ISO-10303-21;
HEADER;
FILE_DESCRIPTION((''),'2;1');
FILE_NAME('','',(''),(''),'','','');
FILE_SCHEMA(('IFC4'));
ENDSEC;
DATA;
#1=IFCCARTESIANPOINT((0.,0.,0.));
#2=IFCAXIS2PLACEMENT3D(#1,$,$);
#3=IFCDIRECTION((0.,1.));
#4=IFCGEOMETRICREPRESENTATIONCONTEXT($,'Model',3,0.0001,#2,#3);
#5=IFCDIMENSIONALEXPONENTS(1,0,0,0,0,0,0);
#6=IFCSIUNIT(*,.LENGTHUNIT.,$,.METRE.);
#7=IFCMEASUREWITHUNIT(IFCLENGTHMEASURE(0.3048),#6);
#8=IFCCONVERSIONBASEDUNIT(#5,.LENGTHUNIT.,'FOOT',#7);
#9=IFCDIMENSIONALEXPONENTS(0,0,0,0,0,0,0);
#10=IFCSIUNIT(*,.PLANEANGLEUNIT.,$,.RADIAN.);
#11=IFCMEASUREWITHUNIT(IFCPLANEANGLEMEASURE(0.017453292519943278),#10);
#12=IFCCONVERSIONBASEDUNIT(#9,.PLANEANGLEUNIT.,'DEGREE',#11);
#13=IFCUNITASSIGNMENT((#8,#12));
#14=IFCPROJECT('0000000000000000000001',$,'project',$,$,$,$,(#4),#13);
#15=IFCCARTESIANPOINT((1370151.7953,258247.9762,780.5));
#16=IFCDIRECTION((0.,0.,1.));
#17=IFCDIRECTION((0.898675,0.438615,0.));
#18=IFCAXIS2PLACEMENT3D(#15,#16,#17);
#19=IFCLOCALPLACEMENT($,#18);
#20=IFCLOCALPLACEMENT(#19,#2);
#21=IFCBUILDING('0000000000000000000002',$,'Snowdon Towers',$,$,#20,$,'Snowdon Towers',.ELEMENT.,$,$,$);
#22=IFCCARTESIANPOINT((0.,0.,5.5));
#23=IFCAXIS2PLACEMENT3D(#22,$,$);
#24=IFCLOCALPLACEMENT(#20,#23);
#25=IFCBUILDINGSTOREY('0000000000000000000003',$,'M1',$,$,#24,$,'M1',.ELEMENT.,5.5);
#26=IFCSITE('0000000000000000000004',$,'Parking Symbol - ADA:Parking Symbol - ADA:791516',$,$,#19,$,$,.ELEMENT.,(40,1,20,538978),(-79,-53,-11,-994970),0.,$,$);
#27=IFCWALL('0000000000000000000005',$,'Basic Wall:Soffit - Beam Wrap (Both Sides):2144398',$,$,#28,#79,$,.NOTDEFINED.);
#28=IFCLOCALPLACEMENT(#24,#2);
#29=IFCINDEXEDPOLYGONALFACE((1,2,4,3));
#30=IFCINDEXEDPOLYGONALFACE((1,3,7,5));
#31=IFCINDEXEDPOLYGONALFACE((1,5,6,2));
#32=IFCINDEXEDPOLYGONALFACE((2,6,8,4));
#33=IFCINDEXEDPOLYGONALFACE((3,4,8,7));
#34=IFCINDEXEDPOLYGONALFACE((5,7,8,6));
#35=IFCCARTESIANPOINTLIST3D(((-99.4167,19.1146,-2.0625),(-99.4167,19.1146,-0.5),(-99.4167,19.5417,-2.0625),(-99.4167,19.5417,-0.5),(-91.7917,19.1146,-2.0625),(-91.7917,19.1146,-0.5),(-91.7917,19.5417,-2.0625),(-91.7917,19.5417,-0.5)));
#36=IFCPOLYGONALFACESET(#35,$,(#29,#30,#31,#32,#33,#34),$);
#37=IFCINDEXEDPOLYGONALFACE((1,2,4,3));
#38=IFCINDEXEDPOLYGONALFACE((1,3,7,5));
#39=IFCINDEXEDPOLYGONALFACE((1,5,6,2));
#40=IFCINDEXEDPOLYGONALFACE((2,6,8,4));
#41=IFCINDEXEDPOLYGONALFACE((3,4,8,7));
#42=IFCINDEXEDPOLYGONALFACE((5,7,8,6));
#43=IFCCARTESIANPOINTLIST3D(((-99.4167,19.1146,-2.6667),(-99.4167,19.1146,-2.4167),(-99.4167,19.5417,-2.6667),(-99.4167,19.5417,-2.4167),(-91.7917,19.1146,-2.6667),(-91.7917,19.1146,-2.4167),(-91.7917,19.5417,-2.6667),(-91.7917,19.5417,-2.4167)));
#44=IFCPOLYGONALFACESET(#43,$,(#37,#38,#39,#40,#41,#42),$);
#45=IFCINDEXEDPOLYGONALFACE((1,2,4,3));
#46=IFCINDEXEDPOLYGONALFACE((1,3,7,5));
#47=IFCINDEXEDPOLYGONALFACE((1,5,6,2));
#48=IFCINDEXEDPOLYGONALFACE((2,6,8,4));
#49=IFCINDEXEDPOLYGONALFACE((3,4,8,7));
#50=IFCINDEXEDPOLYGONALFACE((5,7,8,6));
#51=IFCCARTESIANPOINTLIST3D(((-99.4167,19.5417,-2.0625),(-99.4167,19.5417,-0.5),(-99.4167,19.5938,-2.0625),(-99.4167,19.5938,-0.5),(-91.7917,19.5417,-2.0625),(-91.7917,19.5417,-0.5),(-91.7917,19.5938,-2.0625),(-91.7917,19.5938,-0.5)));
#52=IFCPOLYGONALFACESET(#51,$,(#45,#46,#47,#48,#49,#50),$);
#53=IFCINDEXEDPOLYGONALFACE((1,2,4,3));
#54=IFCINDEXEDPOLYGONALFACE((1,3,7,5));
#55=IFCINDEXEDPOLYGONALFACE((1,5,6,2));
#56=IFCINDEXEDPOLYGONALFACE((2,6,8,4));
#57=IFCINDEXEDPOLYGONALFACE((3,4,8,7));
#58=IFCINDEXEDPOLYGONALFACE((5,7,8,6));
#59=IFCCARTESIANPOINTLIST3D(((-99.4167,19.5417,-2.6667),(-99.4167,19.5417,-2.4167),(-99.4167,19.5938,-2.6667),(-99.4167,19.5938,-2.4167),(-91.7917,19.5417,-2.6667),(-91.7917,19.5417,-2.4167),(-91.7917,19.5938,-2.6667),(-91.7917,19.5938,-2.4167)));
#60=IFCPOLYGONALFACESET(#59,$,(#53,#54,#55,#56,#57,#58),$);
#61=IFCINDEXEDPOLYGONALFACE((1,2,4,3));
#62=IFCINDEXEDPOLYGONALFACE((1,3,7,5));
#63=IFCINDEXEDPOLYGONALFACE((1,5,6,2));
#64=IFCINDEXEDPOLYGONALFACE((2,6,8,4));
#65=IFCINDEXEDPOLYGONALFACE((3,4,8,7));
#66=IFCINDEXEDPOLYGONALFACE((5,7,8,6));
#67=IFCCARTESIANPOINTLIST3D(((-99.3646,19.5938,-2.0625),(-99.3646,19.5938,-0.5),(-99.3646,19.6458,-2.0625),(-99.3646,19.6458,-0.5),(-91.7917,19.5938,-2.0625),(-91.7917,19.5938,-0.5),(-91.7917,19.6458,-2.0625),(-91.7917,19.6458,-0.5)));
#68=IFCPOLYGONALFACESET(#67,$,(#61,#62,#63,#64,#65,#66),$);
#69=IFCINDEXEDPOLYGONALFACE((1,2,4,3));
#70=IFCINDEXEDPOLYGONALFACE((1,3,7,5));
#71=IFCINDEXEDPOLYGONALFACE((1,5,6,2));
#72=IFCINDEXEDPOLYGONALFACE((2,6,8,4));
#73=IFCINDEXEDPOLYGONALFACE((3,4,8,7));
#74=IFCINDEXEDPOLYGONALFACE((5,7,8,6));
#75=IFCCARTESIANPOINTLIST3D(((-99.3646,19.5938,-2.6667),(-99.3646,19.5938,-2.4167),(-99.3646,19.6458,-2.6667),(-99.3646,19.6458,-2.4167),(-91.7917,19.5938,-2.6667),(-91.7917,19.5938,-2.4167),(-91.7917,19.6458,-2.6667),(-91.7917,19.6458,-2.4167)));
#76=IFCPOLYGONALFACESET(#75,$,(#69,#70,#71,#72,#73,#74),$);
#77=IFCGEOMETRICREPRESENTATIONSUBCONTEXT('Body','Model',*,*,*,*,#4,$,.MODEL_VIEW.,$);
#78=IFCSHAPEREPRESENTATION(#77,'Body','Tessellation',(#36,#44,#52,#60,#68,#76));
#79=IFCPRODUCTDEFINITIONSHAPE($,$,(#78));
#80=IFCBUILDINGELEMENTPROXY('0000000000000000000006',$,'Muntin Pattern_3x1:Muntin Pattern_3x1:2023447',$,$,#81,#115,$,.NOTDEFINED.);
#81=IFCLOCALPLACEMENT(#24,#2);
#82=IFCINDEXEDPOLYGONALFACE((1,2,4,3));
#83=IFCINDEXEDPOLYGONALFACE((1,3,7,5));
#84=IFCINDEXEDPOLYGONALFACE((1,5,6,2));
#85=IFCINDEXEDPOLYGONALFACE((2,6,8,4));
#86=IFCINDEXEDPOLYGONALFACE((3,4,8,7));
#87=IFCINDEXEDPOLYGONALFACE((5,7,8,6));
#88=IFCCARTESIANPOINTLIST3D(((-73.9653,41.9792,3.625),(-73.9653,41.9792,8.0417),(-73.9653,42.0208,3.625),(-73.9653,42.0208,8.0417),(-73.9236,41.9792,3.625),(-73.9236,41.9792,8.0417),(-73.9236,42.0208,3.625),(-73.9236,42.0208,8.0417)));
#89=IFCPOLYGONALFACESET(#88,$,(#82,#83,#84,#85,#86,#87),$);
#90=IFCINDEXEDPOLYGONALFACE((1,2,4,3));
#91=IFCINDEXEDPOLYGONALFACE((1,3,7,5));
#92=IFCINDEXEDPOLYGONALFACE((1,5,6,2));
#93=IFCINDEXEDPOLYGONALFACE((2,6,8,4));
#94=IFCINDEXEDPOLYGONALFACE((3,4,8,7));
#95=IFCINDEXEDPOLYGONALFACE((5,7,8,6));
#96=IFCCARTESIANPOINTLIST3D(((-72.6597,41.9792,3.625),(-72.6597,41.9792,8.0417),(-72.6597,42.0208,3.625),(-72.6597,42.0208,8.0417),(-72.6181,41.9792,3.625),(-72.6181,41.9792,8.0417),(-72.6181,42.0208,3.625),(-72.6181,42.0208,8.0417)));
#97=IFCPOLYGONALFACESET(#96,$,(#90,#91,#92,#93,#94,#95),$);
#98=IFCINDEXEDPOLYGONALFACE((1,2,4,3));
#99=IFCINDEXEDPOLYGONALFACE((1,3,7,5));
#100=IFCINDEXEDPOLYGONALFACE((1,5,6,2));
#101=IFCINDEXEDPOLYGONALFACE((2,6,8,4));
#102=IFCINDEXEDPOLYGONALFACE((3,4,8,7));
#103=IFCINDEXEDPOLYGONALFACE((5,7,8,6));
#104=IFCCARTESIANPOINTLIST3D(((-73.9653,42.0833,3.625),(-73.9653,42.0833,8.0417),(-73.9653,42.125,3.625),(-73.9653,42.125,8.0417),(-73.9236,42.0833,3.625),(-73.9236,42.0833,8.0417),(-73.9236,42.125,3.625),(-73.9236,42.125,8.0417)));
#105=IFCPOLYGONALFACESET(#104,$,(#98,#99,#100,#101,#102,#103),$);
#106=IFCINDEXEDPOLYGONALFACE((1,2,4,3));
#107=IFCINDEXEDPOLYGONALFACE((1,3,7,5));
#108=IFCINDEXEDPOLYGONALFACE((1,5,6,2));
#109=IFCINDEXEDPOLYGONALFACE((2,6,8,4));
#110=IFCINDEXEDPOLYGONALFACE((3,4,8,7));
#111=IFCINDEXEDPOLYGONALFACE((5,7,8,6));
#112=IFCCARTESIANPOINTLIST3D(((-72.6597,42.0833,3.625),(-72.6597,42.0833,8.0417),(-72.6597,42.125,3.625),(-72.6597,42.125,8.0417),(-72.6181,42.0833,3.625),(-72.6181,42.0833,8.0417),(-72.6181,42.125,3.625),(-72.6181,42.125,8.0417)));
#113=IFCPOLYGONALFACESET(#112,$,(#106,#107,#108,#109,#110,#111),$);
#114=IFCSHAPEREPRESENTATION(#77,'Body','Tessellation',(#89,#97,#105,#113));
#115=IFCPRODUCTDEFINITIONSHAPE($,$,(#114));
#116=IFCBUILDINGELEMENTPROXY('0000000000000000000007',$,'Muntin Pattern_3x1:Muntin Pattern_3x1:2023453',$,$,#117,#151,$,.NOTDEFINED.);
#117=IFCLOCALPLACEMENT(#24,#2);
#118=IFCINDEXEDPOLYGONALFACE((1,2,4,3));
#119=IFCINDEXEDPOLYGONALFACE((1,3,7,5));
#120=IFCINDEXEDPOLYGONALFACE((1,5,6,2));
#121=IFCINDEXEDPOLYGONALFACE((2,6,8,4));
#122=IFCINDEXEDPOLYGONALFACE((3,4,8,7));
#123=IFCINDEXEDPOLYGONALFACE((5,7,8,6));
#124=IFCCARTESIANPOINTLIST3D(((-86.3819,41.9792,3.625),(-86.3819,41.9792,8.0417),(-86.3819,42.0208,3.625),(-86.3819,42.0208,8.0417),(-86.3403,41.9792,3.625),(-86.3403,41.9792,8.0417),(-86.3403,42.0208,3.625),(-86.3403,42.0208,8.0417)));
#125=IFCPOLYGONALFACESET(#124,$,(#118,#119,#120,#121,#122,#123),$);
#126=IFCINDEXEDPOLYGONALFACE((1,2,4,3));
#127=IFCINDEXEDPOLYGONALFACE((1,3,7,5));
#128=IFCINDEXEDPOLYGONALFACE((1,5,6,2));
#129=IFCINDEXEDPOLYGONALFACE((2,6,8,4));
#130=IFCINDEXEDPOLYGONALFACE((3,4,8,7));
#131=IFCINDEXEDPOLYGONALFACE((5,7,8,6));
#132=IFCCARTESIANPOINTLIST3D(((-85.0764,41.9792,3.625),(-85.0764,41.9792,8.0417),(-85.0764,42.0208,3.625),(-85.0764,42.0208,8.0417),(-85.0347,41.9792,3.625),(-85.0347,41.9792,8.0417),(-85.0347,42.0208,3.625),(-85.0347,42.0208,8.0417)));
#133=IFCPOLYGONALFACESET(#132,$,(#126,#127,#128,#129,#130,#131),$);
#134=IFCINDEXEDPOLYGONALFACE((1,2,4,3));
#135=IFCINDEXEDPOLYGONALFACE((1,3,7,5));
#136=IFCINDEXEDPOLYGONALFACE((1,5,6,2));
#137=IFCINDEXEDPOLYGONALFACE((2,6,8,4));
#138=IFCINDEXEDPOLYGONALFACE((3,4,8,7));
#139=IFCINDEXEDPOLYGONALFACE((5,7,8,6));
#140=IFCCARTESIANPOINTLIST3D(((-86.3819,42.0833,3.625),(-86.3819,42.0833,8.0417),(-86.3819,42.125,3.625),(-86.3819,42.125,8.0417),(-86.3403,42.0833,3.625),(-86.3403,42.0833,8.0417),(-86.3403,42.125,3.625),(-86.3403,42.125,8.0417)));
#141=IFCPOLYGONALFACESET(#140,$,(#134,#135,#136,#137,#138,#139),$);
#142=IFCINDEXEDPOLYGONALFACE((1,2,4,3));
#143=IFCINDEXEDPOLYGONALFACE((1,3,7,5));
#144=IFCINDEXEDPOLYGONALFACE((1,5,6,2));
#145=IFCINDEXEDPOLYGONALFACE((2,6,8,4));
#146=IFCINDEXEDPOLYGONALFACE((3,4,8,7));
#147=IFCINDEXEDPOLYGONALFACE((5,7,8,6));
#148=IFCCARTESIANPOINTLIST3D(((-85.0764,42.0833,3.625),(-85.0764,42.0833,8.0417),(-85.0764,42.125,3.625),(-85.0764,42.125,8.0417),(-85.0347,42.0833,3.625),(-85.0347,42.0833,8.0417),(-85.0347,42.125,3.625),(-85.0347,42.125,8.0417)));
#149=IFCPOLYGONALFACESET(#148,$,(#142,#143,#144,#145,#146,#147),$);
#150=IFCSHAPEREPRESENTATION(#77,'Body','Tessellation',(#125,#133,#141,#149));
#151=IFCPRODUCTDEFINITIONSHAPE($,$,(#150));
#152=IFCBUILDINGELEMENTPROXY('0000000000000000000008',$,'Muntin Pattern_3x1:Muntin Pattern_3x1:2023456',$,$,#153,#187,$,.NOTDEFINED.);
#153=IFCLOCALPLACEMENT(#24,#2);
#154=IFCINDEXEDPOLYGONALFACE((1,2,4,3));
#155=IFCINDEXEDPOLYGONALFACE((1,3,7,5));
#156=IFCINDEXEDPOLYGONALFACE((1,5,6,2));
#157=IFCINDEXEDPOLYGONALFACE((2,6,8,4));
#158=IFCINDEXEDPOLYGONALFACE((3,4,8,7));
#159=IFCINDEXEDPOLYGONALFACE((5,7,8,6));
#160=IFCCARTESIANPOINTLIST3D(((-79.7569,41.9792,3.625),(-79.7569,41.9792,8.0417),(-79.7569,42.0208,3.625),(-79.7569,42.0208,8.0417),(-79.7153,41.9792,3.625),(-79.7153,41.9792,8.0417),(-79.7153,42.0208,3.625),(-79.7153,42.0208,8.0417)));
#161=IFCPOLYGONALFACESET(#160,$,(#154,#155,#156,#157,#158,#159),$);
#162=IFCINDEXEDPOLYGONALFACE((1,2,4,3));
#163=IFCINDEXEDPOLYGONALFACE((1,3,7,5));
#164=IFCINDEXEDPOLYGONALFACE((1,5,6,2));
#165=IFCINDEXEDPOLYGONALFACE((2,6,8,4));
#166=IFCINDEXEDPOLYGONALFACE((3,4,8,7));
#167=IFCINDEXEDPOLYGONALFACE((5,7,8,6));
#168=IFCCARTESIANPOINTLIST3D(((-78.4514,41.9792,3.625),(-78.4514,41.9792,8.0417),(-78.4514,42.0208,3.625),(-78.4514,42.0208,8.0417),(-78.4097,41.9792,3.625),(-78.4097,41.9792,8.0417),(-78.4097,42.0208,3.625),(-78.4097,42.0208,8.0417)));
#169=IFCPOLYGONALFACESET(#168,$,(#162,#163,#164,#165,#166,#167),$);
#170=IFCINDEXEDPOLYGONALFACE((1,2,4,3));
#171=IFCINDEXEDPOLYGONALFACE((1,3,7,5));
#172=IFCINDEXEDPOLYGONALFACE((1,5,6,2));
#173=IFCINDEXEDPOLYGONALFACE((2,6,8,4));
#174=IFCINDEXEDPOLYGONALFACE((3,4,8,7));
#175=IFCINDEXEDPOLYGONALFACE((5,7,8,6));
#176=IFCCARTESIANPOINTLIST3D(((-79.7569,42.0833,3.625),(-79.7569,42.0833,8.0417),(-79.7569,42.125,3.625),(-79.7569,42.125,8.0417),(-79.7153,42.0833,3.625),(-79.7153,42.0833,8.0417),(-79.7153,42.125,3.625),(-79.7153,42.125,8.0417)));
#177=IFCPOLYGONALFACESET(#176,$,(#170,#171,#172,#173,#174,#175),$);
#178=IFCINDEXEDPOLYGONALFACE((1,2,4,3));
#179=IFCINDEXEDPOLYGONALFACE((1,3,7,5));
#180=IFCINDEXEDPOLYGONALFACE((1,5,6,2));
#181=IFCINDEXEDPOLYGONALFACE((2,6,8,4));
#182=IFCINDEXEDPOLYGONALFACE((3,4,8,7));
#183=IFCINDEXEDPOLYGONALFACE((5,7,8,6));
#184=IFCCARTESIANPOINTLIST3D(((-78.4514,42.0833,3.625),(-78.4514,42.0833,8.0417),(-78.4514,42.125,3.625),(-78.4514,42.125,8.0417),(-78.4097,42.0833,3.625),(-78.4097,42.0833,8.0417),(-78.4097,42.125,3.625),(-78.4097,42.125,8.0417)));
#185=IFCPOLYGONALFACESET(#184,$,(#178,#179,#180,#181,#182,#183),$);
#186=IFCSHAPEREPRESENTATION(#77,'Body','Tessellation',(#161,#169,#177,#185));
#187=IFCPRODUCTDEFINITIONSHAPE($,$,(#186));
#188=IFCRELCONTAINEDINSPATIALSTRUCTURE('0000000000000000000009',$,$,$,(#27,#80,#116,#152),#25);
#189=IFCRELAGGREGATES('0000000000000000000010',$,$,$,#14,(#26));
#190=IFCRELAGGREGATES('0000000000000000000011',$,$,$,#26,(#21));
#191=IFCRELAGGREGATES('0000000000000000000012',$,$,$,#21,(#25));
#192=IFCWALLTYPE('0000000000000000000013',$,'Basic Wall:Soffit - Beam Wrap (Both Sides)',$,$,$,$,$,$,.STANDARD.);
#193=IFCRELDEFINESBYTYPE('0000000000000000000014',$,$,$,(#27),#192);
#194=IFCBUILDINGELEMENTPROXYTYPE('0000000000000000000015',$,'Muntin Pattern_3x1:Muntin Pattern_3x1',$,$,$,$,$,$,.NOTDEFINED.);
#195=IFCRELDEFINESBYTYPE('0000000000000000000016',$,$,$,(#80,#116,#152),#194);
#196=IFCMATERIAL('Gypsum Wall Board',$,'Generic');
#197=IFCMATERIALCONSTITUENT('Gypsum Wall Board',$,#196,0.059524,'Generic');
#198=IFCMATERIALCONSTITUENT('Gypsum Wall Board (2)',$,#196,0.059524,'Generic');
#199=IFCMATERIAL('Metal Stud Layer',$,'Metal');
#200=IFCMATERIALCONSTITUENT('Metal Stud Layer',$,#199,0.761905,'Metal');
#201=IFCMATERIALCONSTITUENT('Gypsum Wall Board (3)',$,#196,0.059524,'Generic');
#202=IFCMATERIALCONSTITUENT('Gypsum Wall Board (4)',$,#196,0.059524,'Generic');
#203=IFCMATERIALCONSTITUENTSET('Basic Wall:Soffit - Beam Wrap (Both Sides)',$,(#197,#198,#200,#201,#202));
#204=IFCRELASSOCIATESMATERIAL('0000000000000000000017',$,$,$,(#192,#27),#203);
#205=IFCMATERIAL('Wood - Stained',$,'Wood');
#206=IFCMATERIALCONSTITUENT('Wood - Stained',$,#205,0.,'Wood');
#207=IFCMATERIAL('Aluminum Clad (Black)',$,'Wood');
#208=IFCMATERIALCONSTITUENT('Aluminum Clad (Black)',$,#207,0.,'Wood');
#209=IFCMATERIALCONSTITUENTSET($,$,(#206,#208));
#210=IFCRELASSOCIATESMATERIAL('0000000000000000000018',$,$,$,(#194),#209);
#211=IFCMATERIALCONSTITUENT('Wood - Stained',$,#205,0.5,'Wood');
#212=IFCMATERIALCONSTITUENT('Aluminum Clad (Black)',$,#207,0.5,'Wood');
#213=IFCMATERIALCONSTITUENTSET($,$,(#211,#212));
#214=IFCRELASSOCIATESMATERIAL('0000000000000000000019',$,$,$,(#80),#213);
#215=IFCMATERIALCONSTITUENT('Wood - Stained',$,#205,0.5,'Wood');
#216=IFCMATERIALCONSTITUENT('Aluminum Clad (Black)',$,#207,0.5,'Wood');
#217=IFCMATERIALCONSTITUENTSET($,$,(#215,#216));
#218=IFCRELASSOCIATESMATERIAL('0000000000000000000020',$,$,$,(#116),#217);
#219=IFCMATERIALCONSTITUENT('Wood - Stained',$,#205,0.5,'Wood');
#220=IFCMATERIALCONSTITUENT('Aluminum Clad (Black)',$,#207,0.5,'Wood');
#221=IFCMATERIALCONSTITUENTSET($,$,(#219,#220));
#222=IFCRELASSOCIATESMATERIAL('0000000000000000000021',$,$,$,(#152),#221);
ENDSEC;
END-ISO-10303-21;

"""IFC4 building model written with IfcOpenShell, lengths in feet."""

from ifc_helpers import new_model, entity, si_unit, converted_unit, direction, frame, origin, place, context, subcontext, project, spatial, indexed_curve, outline, extrude, source, transform, mapped, material, constituent, constituent_set, type_object, type_shapes, element, save


model = new_model("IFC4")

# Units and contexts
model_context = context("Model", 3, precision=0.0001, world=origin(), true_north=direction((0.0, 1.0)))
body_context = subcontext(model_context, "Body", "Model", "MODEL_VIEW")
ifc_project = project(units=[converted_unit("LENGTHUNIT", "FOOT", entity("IfcLengthMeasure", 0.3048), si_unit("LENGTHUNIT", "METRE"), dimensions=[1, 0, 0, 0, 0, 0, 0]), converted_unit("PLANEANGLEUNIT", "DEGREE", entity("IfcPlaneAngleMeasure", 0.017453292519943278), si_unit("PLANEANGLEUNIT", "RADIAN"), dimensions=[0, 0, 0, 0, 0, 0, 0])], contexts=[model_context])

# Site, building, storey
site_placement = place(None, frame((1370151.7953, 258247.9762, 780.5), z_axis=(0.0, 0.0, 1.0), x_axis=(0.898675, 0.438615, 0.0)))
site = spatial("IfcSite", under=ifc_project, at=site_placement, Name="Parking Symbol - ADA:Parking Symbol - ADA:791516", CompositionType="ELEMENT", RefLatitude=(40, 1, 20, 538978), RefLongitude=(-79, -53, -11, -994970), RefElevation=0.0)
building_placement = place(site_placement, origin())
building = spatial("IfcBuilding", under=site, at=building_placement, Name="Snowdon Towers", LongName="Snowdon Towers", CompositionType="ELEMENT")
storey_placement = place(building_placement, frame((0.0, 0.0, 5.5)))
storey = spatial("IfcBuildingStorey", under=building, at=storey_placement, Name="M1", LongName="M1", CompositionType="ELEMENT", Elevation=5.5)

# Shared definitions
ifc_material_1 = material(Name="Gypsum Wall Board", Category="Generic")

# Wall
ifc_constituent_1 = constituent(ifc_material_1, Name="Gypsum Wall Board", Category="Generic", fraction=0.059524)
ifc_constituent_2 = constituent(ifc_material_1, Name="Gypsum Wall Board (2)", Category="Generic", fraction=0.059524)
ifc_material_2 = material(Name="Metal Stud Layer", Category="Metal")
ifc_constituent_3 = constituent(ifc_material_2, Name="Metal Stud Layer", Category="Metal", fraction=0.761905)
ifc_constituent_4 = constituent(ifc_material_1, Name="Gypsum Wall Board (3)", Category="Generic", fraction=0.059524)
ifc_constituent_5 = constituent(ifc_material_1, Name="Gypsum Wall Board (4)", Category="Generic", fraction=0.059524)
ifc_constituent_set_1 = constituent_set(constituents=[ifc_constituent_1, ifc_constituent_2, ifc_constituent_3, ifc_constituent_4, ifc_constituent_5], Name="Basic Wall:Soffit - Beam Wrap (Both Sides)")
wall_type_1 = type_object("IfcWallType", Name="Basic Wall:Soffit - Beam Wrap (Both Sides)", PredefinedType="STANDARD", material=ifc_constituent_set_1)
wall_1_placement = place(storey_placement, frame((-99.3646, 19.2083, -2.6667)))
element("IfcWall", 1, at=wall_1_placement, inside=storey, type_object=wall_type_1, material=ifc_constituent_set_1, Name="Basic Wall:Soffit - Beam Wrap (Both Sides):2144398", PredefinedType="NOTDEFINED", context=body_context, shape_type="SweptSolid", body=[
    extrude(outline(indexed_curve([(-0.2135, -3.8125), (0.2135, -3.8125), (0.2135, 3.8125), (-0.2135, 3.8125), (-0.2135, -3.8125)], self_intersect=False)), frame((3.7604, 0.1198, 0.6042), z_axis=(0.0, 0.0, 1.0), x_axis=(0.0, 1.0, 0.0)), (0.0, 0.0, 1.0), 1.5625),
    extrude(outline(indexed_curve([(-0.2135, -3.8125), (0.2135, -3.8125), (0.2135, 3.8125), (-0.2135, 3.8125), (-0.2135, -3.8125)], self_intersect=False)), frame((3.7604, 0.1198, 0.0), z_axis=(0.0, 0.0, 1.0), x_axis=(0.0, 1.0, 0.0)), (0.0, 0.0, 1.0), 0.25),
    extrude(outline(indexed_curve([(-3.8125, -0.026), (3.8125, -0.026), (3.8125, 0.026), (-3.8125, 0.026), (-3.8125, -0.026)], self_intersect=False)), frame((3.7604, 0.3594, 0.6042), z_axis=(0.0, 0.0, 1.0), x_axis=(-1.0, 0.0, 0.0)), (0.0, 0.0, 1.0), 1.5625),
    extrude(outline(indexed_curve([(-3.8125, -0.026), (3.8125, -0.026), (3.8125, 0.026), (-3.8125, 0.026), (-3.8125, -0.026)], self_intersect=False)), frame((3.7604, 0.3594, 0.0)), (0.0, 0.0, 1.0), 0.25),
    extrude(outline(indexed_curve([(-0.026, -3.7865), (0.026, -3.7865), (0.026, 3.7865), (-0.026, 3.7865), (-0.026, -3.7865)], self_intersect=False)), frame((3.7865, 0.4115, 0.6042), z_axis=(0.0, 0.0, 1.0), x_axis=(0.0, -1.0, 0.0)), (0.0, 0.0, 1.0), 1.5625),
    extrude(outline(indexed_curve([(-0.026, -3.7865), (0.026, -3.7865), (0.026, 3.7865), (-0.026, 3.7865), (-0.026, -3.7865)], self_intersect=False)), frame((3.7865, 0.4115, 0.0), z_axis=(0.0, 0.0, 1.0), x_axis=(0.0, -1.0, 0.0)), (0.0, 0.0, 1.0), 0.25),
])

# Building element proxies
ifc_material_3 = material(Name="Wood - Stained", Category="Wood")
ifc_constituent_6 = constituent(ifc_material_3, Name="Wood - Stained", Category="Wood", fraction=0.5)
ifc_material_4 = material(Name="Aluminum Clad (Black)", Category="Wood")
ifc_constituent_7 = constituent(ifc_material_4, Name="Aluminum Clad (Black)", Category="Wood", fraction=0.5)
ifc_constituent_set_2 = constituent_set(constituents=[ifc_constituent_6, ifc_constituent_7])
ifc_constituent_8 = constituent(ifc_material_3, Name="Wood - Stained", Category="Wood", fraction=0.0)
ifc_constituent_9 = constituent(ifc_material_4, Name="Aluminum Clad (Black)", Category="Wood", fraction=0.0)
ifc_constituent_set_3 = constituent_set(constituents=[ifc_constituent_8, ifc_constituent_9])
building_element_proxy_type_1 = type_object("IfcBuildingElementProxyType", Name="Muntin Pattern_3x1:Muntin Pattern_3x1", PredefinedType="NOTDEFINED", material=ifc_constituent_set_3)
shared_shape_1 = source(origin(), body_context, "Body", "SweptSolid", [
    extrude(outline(indexed_curve([(-0.0208, -0.0208), (0.0208, -0.0208), (0.0208, 0.0208), (-0.0208, 0.0208), (-0.0208, -0.0208)], self_intersect=False)), frame((0.6528, 0.0521, 0.0)), (0.0, 0.0, 1.0), 4.4167),
    extrude(outline(indexed_curve([(-0.0208, -0.0208), (0.0208, -0.0208), (0.0208, 0.0208), (-0.0208, 0.0208), (-0.0208, -0.0208)], self_intersect=False)), frame((-0.6528, 0.0521, 0.0)), (0.0, 0.0, 1.0), 4.4167),
    extrude(outline(indexed_curve([(-0.0208, -0.0208), (0.0208, -0.0208), (0.0208, 0.0208), (-0.0208, 0.0208), (-0.0208, -0.0208)], self_intersect=False)), frame((0.6528, -0.0521, 0.0)), (0.0, 0.0, 1.0), 4.4167),
    extrude(outline(indexed_curve([(-0.0208, -0.0208), (0.0208, -0.0208), (0.0208, 0.0208), (-0.0208, 0.0208), (-0.0208, -0.0208)], self_intersect=False)), frame((-0.6528, -0.0521, 0.0)), (0.0, 0.0, 1.0), 4.4167),
])
type_shapes(building_element_proxy_type_1, [shared_shape_1])
proxy_1_placement = place(storey_placement, frame((-73.2917, 42.0521, 3.625), z_axis=(0.0, 0.0, 1.0), x_axis=(-1.0, 0.0, 0.0)))
element("IfcBuildingElementProxy", 2, at=proxy_1_placement, inside=storey, type_object=building_element_proxy_type_1, material=ifc_constituent_set_2, Name="Muntin Pattern_3x1:Muntin Pattern_3x1:2023447", PredefinedType="NOTDEFINED", context=body_context, shape_type="MappedRepresentation", body=[
    mapped(shared_shape_1, transform((0.0, 0.0, 0.0), scale=1.0)),
])
ifc_constituent_10 = constituent(ifc_material_3, Name="Wood - Stained", Category="Wood", fraction=0.5)
ifc_constituent_11 = constituent(ifc_material_4, Name="Aluminum Clad (Black)", Category="Wood", fraction=0.5)
ifc_constituent_set_4 = constituent_set(constituents=[ifc_constituent_10, ifc_constituent_11])
proxy_2_placement = place(storey_placement, frame((-85.7083, 42.0521, 3.625), z_axis=(0.0, 0.0, 1.0), x_axis=(-1.0, 0.0, 0.0)))
element("IfcBuildingElementProxy", 3, at=proxy_2_placement, inside=storey, type_object=building_element_proxy_type_1, material=ifc_constituent_set_4, Name="Muntin Pattern_3x1:Muntin Pattern_3x1:2023453", PredefinedType="NOTDEFINED", context=body_context, shape_type="MappedRepresentation", body=[
    mapped(shared_shape_1, transform((0.0, 0.0, 0.0), scale=1.0)),
])
ifc_constituent_12 = constituent(ifc_material_3, Name="Wood - Stained", Category="Wood", fraction=0.5)
ifc_constituent_13 = constituent(ifc_material_4, Name="Aluminum Clad (Black)", Category="Wood", fraction=0.5)
ifc_constituent_set_5 = constituent_set(constituents=[ifc_constituent_12, ifc_constituent_13])
proxy_3_placement = place(storey_placement, frame((-79.0833, 42.0521, 3.625), z_axis=(0.0, 0.0, 1.0), x_axis=(-1.0, 0.0, 0.0)))
element("IfcBuildingElementProxy", 4, at=proxy_3_placement, inside=storey, type_object=building_element_proxy_type_1, material=ifc_constituent_set_5, Name="Muntin Pattern_3x1:Muntin Pattern_3x1:2023456", PredefinedType="NOTDEFINED", context=body_context, shape_type="MappedRepresentation", body=[
    mapped(shared_shape_1, transform((0.0, 0.0, 0.0), scale=1.0)),
])

save(model, "model.ifc")
